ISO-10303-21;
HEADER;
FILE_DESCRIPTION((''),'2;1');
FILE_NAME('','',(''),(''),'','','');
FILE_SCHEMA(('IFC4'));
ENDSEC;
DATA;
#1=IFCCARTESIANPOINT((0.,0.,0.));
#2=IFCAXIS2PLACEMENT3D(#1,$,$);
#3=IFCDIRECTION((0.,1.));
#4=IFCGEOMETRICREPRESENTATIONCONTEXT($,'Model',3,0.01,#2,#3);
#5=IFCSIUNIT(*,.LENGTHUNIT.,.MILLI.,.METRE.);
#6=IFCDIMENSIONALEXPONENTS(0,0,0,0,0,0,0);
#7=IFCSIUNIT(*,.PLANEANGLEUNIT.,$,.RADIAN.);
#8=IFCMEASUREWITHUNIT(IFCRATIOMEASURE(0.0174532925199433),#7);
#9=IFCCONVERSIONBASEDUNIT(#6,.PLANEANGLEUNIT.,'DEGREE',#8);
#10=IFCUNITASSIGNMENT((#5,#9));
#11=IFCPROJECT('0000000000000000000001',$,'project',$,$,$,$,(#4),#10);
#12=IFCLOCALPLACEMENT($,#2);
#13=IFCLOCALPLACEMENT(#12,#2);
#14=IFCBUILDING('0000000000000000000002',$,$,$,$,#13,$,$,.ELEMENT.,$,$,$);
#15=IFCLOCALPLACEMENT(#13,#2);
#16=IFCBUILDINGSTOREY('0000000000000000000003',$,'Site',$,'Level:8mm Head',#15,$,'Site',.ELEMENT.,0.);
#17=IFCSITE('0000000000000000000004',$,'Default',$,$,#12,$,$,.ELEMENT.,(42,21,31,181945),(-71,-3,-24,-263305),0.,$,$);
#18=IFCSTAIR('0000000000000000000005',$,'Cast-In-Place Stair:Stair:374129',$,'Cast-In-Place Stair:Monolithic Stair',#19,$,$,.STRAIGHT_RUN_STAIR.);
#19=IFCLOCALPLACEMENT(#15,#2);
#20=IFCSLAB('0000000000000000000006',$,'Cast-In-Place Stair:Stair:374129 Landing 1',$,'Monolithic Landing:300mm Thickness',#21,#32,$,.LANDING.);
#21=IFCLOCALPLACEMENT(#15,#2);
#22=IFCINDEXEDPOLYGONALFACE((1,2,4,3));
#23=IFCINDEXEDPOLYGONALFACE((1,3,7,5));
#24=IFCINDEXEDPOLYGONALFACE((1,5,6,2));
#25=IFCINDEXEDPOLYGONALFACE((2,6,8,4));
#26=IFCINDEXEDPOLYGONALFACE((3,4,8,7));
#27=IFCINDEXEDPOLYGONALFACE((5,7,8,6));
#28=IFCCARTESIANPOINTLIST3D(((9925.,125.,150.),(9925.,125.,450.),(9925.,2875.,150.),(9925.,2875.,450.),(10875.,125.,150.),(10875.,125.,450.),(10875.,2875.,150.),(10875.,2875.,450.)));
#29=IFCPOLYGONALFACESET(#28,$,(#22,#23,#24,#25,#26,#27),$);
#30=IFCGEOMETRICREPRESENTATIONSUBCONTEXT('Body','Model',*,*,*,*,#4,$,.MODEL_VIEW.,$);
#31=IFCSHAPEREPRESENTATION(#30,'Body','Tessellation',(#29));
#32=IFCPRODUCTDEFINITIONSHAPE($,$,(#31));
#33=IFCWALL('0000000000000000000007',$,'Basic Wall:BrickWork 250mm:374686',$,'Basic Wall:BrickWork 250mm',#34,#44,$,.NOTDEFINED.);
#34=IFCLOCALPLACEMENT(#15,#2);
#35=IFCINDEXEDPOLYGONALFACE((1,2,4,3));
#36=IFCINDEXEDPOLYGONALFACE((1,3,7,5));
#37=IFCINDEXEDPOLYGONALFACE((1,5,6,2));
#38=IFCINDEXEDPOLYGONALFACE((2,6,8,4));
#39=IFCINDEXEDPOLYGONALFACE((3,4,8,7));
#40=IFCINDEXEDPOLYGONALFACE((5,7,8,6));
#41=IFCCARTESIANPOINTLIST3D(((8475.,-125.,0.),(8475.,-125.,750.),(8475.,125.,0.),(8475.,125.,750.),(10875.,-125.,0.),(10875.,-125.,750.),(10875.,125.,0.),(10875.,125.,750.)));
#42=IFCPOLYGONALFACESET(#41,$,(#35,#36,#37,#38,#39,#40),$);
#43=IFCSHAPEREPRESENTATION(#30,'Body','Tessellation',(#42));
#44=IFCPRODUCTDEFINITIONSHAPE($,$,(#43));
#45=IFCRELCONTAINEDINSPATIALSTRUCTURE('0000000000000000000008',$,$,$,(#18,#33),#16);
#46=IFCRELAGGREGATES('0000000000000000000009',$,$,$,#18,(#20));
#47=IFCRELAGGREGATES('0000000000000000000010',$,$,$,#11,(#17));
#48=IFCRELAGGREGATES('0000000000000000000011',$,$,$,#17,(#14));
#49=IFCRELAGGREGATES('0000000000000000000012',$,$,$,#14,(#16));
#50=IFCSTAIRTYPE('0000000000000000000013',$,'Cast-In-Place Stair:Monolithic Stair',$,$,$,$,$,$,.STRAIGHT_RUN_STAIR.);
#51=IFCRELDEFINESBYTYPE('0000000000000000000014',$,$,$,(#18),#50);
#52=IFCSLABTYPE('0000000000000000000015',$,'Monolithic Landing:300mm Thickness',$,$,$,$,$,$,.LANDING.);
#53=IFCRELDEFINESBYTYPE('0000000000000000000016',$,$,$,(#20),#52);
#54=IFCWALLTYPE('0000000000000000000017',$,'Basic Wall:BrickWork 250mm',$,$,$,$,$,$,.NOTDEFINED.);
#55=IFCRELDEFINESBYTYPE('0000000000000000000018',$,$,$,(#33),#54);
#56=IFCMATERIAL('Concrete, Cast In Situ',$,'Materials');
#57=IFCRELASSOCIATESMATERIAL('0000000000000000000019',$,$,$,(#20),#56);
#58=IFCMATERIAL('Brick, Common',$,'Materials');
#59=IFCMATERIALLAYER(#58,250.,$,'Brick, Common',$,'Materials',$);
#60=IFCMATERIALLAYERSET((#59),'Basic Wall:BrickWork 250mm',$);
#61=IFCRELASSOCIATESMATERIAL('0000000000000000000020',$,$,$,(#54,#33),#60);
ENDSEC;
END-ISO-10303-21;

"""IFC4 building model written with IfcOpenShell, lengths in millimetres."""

from ifc_helpers import new_model, entity, si_unit, converted_unit, direction, frame, frame_2d, origin, place, context, subcontext, project, spatial, rectangle, extrude, material, layer, layer_set, layer_usage, type_object, element, aggregate, save


model = new_model("IFC4")

# Units and contexts
model_context = context("Model", 3, precision=0.01, world=origin(), true_north=direction((0.0, 1.0)))
body_context = subcontext(model_context, "Body", "Model", "MODEL_VIEW")
ifc_project = project(units=[si_unit("LENGTHUNIT", "METRE", prefix="MILLI"), converted_unit("PLANEANGLEUNIT", "DEGREE", entity("IfcRatioMeasure", 0.0174532925199433), si_unit("PLANEANGLEUNIT", "RADIAN"), dimensions=[0, 0, 0, 0, 0, 0, 0])], contexts=[model_context])

# Site, building, storey
site_placement = place(None, origin())
site = spatial("IfcSite", under=ifc_project, at=site_placement, Name="Default", CompositionType="ELEMENT", RefLatitude=(42, 21, 31, 181945), RefLongitude=(-71, -3, -24, -263305), RefElevation=0.0)
building_placement = place(site_placement, origin())
building = spatial("IfcBuilding", under=site, at=building_placement, CompositionType="ELEMENT")
storey_placement = place(building_placement, origin())
storey = spatial("IfcBuildingStorey", under=building, at=storey_placement, Name="Site", ObjectType="Level:8mm Head", LongName="Site", CompositionType="ELEMENT", Elevation=0.0)

# Stair, slab
stair_type = type_object("IfcStairType", Name="Cast-In-Place Stair:Monolithic Stair", PredefinedType="STRAIGHT_RUN_STAIR")
stair_placement = place(storey_placement, origin())
stair = element("IfcStair", 1, at=stair_placement, inside=storey, type_object=stair_type, Name="Cast-In-Place Stair:Stair:374129", ObjectType="Cast-In-Place Stair:Monolithic Stair", PredefinedType="STRAIGHT_RUN_STAIR")
ifc_material_1 = material(Name="Concrete, Cast In Situ", Category="Materials")
slab_type = type_object("IfcSlabType", Name="Monolithic Landing:300mm Thickness", PredefinedType="LANDING")
slab_placement = place(stair_placement, frame((9925.0, 125.0, 0.0)))
slab = element("IfcSlab", 2, at=slab_placement, type_object=slab_type, material=ifc_material_1, Name="Cast-In-Place Stair:Stair:374129 Landing 1", ObjectType="Monolithic Landing:300mm Thickness", PredefinedType="LANDING", context=body_context, shape_type="SweptSolid", body=[
    extrude(rectangle(XDim=950.0, YDim=2750.0, at=frame_2d((0.0, 0.0), x_axis=(1.0, 0.0))), frame((475.0, 1375.0, 150.0)), (0.0, 0.0, 1.0), 300.0),
])
aggregate(stair, [slab])

# Wall
ifc_material_2 = material(Name="Brick, Common", Category="Materials")
ifc_layer = layer(ifc_material_2, 250.0, Name="Brick, Common", Category="Materials")
ifc_layer_set = layer_set([ifc_layer], Name="Basic Wall:BrickWork 250mm")
ifc_layer_usage = layer_usage(ifc_layer_set, "AXIS2", "NEGATIVE", 125.0)
wall_type = type_object("IfcWallType", Name="Basic Wall:BrickWork 250mm", PredefinedType="NOTDEFINED", material=ifc_layer_set)
wall_placement = place(storey_placement, frame((8475.0, 0.0, 0.0)))
element("IfcWall", 3, at=wall_placement, inside=storey, type_object=wall_type, material=ifc_layer_usage, Name="Basic Wall:BrickWork 250mm:374686", ObjectType="Basic Wall:BrickWork 250mm", PredefinedType="NOTDEFINED", context=body_context, shape_type="SweptSolid", body=[
    extrude(rectangle(XDim=2400.0, YDim=250.0, at=frame_2d((1200.0, 0.0), x_axis=(-1.0, 0.0))), origin(), (0.0, 0.0, 1.0), 750.0),
])

save(model, "model.ifc")
